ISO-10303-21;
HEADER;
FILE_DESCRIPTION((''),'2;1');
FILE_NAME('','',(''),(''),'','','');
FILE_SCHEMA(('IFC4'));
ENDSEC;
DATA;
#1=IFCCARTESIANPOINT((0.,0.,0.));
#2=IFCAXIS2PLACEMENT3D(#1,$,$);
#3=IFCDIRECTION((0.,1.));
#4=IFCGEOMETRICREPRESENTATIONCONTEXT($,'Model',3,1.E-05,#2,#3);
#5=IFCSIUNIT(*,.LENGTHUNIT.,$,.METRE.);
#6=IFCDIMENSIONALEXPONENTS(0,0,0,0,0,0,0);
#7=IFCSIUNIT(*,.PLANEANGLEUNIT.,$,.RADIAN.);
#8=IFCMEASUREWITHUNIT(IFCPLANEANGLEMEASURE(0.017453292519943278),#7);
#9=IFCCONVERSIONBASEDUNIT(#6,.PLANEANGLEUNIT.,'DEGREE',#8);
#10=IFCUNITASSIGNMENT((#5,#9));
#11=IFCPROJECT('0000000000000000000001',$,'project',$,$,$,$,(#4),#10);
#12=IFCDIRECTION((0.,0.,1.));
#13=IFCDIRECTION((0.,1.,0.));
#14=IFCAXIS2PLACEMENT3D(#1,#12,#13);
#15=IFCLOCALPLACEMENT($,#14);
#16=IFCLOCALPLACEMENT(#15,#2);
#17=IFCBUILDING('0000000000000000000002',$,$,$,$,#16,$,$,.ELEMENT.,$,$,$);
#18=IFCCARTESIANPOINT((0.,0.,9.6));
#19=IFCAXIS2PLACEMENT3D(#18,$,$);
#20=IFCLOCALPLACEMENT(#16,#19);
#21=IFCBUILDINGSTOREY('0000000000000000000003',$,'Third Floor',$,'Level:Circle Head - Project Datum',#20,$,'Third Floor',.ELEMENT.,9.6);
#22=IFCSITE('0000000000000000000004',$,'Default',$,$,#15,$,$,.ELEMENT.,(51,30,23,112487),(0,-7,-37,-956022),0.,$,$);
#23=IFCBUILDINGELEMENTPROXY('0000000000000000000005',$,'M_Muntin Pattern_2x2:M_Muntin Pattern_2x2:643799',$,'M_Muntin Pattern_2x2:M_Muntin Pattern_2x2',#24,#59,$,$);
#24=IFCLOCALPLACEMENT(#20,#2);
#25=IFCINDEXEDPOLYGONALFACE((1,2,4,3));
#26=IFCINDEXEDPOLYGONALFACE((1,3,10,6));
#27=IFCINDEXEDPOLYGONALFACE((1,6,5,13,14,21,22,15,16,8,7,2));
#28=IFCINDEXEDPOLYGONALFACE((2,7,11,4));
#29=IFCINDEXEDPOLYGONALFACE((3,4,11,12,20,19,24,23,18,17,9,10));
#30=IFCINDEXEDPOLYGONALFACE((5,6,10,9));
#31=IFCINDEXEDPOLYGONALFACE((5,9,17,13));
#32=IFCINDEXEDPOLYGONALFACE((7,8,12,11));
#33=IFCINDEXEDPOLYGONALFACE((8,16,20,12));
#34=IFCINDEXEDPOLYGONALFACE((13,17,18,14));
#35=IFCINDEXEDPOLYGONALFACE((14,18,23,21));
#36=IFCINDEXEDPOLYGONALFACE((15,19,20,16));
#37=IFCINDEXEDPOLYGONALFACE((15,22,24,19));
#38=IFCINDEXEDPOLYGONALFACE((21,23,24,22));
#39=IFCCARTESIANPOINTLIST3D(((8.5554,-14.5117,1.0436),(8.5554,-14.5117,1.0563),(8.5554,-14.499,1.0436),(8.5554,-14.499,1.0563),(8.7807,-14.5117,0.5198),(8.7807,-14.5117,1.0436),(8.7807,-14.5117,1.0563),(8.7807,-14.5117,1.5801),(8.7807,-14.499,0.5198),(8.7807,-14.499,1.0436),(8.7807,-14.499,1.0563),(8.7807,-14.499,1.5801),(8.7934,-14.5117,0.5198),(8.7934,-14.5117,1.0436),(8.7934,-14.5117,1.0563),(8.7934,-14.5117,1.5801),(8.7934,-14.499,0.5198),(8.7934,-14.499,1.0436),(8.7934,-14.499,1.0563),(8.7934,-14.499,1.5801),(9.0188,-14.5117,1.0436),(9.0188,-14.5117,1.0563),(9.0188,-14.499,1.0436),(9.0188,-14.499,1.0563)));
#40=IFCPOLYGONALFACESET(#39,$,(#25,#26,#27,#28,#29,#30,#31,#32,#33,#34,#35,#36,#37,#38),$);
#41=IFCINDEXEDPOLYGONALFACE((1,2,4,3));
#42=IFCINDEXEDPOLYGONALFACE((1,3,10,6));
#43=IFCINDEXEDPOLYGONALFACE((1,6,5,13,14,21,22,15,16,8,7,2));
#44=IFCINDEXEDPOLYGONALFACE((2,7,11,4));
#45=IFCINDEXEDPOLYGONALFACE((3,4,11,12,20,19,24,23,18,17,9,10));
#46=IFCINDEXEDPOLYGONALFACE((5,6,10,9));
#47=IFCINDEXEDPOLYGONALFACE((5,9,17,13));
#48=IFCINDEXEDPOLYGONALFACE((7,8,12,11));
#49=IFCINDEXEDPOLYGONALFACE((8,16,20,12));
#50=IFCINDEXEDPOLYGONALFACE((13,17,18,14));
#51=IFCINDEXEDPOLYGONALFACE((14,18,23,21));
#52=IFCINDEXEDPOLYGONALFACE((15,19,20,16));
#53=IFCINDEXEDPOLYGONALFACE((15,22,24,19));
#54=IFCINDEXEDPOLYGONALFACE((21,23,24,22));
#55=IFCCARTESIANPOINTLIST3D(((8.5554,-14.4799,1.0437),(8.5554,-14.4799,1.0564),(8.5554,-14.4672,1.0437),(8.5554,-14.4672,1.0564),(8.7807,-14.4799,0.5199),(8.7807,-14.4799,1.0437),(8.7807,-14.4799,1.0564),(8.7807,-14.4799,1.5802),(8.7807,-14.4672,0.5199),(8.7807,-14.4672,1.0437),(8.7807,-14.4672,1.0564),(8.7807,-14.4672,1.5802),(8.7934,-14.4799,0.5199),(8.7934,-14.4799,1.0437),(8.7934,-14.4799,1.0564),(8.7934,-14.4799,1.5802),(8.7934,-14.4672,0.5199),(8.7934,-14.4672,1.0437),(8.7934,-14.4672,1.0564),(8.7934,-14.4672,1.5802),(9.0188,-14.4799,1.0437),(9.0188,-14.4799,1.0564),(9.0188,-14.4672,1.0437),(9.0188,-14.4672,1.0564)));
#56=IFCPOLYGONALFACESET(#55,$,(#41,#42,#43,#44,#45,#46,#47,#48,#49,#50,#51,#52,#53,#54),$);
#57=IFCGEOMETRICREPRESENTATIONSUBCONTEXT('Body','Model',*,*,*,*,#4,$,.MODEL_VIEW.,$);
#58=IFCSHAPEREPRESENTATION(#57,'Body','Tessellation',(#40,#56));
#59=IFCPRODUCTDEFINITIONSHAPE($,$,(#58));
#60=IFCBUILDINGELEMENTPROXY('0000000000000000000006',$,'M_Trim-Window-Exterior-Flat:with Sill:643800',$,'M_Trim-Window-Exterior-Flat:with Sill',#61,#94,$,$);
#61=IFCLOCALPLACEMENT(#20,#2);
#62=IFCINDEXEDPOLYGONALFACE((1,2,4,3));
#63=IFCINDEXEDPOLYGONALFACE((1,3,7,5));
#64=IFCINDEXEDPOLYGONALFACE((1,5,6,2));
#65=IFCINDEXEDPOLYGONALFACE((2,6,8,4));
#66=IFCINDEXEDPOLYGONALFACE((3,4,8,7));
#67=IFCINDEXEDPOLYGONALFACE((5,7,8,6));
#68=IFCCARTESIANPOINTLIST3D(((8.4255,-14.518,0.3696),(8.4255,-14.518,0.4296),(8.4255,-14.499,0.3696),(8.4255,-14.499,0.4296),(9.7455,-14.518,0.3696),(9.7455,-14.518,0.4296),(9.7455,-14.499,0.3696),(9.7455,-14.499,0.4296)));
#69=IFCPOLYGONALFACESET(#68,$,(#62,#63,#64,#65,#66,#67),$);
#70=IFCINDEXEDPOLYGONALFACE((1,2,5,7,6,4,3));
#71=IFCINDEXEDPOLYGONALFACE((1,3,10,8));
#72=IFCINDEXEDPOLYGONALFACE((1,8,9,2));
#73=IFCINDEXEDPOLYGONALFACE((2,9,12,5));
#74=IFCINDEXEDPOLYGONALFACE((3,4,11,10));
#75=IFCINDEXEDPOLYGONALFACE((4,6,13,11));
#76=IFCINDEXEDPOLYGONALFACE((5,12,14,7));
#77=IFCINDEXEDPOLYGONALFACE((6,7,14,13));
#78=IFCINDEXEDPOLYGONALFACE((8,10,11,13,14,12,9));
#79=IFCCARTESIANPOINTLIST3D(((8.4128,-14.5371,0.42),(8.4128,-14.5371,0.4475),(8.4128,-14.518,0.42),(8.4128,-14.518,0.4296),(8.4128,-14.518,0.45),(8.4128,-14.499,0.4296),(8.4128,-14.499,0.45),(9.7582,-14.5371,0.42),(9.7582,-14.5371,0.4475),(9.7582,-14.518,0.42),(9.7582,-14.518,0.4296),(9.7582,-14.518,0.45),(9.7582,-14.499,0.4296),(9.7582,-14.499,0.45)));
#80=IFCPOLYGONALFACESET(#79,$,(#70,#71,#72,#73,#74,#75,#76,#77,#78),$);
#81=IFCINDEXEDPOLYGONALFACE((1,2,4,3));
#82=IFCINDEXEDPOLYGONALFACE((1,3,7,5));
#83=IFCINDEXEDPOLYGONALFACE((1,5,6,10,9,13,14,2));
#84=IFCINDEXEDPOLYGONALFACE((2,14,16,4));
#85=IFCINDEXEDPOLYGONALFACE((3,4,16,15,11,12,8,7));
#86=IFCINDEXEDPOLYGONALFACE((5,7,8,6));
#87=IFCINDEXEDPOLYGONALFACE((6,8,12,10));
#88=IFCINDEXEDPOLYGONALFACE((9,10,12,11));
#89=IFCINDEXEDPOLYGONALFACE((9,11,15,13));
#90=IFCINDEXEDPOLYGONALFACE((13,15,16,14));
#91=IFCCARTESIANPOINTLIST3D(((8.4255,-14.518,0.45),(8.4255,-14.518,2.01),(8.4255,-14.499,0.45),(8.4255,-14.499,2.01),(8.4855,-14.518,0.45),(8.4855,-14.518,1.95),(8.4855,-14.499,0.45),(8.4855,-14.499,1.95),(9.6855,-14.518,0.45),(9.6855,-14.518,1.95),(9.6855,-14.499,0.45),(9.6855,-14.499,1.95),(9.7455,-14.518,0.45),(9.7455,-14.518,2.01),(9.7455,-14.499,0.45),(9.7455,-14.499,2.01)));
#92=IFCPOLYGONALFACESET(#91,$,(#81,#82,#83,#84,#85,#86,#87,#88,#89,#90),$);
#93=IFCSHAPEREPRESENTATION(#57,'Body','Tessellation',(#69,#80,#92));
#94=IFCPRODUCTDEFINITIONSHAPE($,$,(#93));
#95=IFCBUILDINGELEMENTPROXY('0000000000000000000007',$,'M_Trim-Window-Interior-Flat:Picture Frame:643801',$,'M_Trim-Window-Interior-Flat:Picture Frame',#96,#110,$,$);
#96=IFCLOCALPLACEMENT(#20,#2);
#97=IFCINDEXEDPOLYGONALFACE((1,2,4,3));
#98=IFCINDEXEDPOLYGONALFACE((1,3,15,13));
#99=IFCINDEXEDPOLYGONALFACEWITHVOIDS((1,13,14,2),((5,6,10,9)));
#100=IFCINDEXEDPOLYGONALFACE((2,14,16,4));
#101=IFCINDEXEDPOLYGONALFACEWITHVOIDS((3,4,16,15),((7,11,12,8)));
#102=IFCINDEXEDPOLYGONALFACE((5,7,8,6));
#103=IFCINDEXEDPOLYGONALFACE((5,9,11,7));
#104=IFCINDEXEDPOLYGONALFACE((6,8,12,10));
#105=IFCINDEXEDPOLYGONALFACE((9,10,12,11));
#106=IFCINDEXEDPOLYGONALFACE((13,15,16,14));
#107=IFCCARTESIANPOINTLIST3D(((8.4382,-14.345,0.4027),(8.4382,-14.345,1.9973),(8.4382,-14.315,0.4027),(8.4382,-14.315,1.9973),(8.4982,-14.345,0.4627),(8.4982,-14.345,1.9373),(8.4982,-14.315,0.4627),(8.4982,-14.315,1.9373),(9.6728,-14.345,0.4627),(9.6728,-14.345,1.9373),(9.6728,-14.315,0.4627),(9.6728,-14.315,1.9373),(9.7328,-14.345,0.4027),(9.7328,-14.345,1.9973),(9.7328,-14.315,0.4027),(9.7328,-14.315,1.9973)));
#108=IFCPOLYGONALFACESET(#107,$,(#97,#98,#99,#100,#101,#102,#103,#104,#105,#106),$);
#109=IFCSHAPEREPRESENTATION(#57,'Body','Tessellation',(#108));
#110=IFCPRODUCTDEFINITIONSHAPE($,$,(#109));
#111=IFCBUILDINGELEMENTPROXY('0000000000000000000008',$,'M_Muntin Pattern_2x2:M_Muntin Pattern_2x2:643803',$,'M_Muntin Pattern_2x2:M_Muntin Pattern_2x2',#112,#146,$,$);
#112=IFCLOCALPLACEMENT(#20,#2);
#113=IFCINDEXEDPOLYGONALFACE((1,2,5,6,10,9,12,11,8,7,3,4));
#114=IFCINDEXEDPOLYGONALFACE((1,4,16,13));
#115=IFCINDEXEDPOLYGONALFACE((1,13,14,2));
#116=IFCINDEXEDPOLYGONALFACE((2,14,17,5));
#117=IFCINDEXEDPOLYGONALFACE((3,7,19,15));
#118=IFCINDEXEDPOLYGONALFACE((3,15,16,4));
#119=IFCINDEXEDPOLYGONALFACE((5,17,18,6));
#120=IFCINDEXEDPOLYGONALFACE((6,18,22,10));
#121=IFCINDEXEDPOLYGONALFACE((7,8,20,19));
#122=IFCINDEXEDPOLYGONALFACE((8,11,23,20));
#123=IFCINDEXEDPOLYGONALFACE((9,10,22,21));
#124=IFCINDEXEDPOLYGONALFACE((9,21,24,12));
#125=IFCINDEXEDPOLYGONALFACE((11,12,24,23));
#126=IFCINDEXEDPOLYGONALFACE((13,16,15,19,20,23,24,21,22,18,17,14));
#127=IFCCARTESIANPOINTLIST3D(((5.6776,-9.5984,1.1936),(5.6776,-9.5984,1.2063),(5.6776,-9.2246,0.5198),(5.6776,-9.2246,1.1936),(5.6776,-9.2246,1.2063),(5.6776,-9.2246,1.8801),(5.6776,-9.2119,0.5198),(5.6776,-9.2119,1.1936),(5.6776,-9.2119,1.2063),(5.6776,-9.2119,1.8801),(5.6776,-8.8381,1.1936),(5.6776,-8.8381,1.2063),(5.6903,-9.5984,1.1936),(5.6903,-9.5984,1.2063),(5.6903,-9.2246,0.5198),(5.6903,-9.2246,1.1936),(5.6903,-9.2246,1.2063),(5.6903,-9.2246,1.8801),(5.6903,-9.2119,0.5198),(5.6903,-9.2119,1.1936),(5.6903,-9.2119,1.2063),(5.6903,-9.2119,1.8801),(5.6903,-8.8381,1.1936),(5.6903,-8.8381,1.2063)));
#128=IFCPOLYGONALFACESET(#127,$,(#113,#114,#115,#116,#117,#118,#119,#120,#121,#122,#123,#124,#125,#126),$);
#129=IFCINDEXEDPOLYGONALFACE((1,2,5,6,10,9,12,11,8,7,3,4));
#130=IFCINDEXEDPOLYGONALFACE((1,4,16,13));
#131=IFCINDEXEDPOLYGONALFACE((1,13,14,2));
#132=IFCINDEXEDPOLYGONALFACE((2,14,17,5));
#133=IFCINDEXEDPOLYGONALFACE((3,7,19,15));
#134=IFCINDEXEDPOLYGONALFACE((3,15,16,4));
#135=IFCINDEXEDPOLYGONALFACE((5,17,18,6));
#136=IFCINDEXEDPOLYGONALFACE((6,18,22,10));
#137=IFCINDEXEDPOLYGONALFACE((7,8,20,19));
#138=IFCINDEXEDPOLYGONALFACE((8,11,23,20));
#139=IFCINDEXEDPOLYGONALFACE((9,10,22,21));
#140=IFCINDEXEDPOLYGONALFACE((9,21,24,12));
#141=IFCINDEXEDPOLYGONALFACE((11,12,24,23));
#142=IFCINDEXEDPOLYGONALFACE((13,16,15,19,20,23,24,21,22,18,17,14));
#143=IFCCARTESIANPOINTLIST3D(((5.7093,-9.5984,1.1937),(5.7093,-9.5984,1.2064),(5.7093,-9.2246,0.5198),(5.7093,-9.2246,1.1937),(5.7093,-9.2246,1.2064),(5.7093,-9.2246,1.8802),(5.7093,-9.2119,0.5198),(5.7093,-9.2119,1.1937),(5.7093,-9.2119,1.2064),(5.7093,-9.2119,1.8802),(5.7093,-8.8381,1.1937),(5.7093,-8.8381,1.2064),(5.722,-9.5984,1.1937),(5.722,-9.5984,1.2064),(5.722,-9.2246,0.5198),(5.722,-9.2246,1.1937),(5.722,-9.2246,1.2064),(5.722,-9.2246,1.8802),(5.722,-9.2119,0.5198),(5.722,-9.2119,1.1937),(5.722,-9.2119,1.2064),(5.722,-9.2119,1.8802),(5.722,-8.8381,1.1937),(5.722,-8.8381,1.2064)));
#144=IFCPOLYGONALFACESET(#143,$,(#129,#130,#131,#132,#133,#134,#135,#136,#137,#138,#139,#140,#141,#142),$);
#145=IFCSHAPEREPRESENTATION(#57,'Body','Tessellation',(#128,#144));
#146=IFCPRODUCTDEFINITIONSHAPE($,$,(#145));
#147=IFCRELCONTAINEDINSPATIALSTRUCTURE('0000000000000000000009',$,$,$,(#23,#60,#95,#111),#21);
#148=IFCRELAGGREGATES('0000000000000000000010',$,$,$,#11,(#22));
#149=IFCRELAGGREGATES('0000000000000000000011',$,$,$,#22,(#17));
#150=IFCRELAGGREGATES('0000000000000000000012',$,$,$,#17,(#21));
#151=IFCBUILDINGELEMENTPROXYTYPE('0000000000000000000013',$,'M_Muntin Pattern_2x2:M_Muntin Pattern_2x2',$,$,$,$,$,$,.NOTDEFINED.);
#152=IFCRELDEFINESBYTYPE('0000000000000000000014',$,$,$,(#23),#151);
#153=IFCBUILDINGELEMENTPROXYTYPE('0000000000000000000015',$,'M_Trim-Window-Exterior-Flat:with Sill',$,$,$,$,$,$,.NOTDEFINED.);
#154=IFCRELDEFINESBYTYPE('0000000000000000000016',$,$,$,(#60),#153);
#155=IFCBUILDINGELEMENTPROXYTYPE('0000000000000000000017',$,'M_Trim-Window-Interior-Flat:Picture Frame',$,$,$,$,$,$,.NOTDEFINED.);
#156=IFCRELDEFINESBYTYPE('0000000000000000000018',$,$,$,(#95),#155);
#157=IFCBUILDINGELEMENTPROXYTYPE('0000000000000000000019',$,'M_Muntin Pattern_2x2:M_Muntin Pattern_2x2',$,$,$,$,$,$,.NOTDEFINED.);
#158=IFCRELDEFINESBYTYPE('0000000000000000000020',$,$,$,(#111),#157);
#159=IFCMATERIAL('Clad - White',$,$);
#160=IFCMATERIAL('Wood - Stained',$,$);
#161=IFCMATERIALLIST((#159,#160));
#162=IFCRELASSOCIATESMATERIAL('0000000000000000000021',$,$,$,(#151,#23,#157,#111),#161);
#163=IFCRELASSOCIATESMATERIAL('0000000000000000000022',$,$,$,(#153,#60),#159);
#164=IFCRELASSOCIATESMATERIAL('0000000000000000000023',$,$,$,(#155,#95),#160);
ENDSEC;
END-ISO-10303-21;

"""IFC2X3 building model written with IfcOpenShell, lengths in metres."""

from ifc_helpers import new_model, entity, si_unit, converted_unit, direction, frame, frame_2d, origin, place, context, subcontext, project, spatial, polyline, rectangle, outline, extrude, source, transform, mapped, material, material_list, type_object, type_shapes, element, save


model = new_model("IFC2X3")

# Units and contexts
model_context = context("Model", 3, precision=1e-05, world=origin(), true_north=direction((0.0, 1.0)))
body_context = subcontext(model_context, "Body", "Model", "MODEL_VIEW")
ifc_project = project(units=[si_unit("LENGTHUNIT", "METRE"), converted_unit("PLANEANGLEUNIT", "DEGREE", entity("IfcPlaneAngleMeasure", 0.017453292519943278), si_unit("PLANEANGLEUNIT", "RADIAN"), dimensions=[0, 0, 0, 0, 0, 0, 0])], contexts=[model_context])

# Site, building, storey
site_placement = place(None, frame((0.0, 0.0, 0.0), z_axis=(0.0, 0.0, 1.0), x_axis=(0.0, 1.0, 0.0)))
site = spatial("IfcSite", under=ifc_project, at=site_placement, Name="Default", CompositionType="ELEMENT", RefLatitude=(51, 30, 23, 112487), RefLongitude=(0, -7, -37, -956022), RefElevation=0.0)
building_placement = place(site_placement, origin())
building = spatial("IfcBuilding", under=site, at=building_placement, CompositionType="ELEMENT")
storey_placement = place(building_placement, frame((0.0, 0.0, 9.6)))
storey = spatial("IfcBuildingStorey", under=building, at=storey_placement, Name="Third Floor", ObjectType="Level:Circle Head - Project Datum", LongName="Third Floor", CompositionType="ELEMENT", Elevation=9.6)

# Building element proxies
ifc_material_1 = material(Name="Clad - White")
ifc_material_2 = material(Name="Wood - Stained")
ifc_material_list = material_list([ifc_material_1, ifc_material_2])
building_element_proxy_type_1 = type_object("IfcBuildingElementProxyType", Name="M_Muntin Pattern_2x2:M_Muntin Pattern_2x2", PredefinedType="NOTDEFINED", material=ifc_material_list)
shared_shape_1 = source(origin(), body_context, "Body", "SweptSolid", [
    extrude(outline(polyline([(0.0064, -0.0064), (0.5301, -0.0064), (0.5301, 0.0063), (0.0064, 0.0063), (0.0064, 0.2317), (-0.0063, 0.2317), (-0.0063, 0.0063), (-0.5302, 0.0063), (-0.5302, -0.0064), (-0.0063, -0.0064), (-0.0063, -0.2317), (0.0064, -0.2317), (0.0064, -0.0064)])), frame((0.0, -0.0222, 0.5301), z_axis=(0.0, 1.0, 0.0), x_axis=(0.0, 0.0, 1.0)), (0.0, 0.0, 1.0), 0.0127),
    extrude(outline(polyline([(0.0064, -0.0064), (0.5302, -0.0064), (0.5302, 0.0063), (0.0064, 0.0063), (0.0064, 0.2317), (-0.0063, 0.2317), (-0.0063, 0.0063), (-0.5302, 0.0063), (-0.5302, -0.0064), (-0.0063, -0.0064), (-0.0063, -0.2317), (0.0064, -0.2317), (0.0064, -0.0064)])), frame((0.0, 0.0095, 0.5302), z_axis=(0.0, 1.0, 0.0), x_axis=(0.0, 0.0, 1.0)), (0.0, 0.0, 1.0), 0.0127),
])
type_shapes(building_element_proxy_type_1, [shared_shape_1])
proxy_1_placement = place(storey_placement, frame((8.7871, -14.4895, 0.5199)))
element("IfcBuildingElementProxy", 1, at=proxy_1_placement, inside=storey, type_object=building_element_proxy_type_1, material=ifc_material_list, Name="M_Muntin Pattern_2x2:M_Muntin Pattern_2x2:643799", ObjectType="M_Muntin Pattern_2x2:M_Muntin Pattern_2x2", context=body_context, shape_type="MappedRepresentation", body=[
    mapped(shared_shape_1, transform((0.0, 0.0, 0.0), scale=1.0)),
])
building_element_proxy_type_2 = type_object("IfcBuildingElementProxyType", Name="M_Trim-Window-Exterior-Flat:with Sill", PredefinedType="NOTDEFINED", material=ifc_material_1)
shared_shape_2 = source(origin(), body_context, "Body", "SweptSolid", [
    extrude(rectangle(XDim=1.32, YDim=0.06, at=frame_2d((0.0, 0.0), x_axis=(1.0, 0.0))), frame((0.0, -1.5504, 0.0), z_axis=(0.0, 0.0, 1.0), x_axis=(-1.0, 0.0, 0.0)), (0.0, 0.0, 1.0), 0.019),
    extrude(outline(polyline([(-0.019, -0.0152), (0.0, -0.0152), (0.0, -0.0057), (0.019, -0.0057), (0.019, 0.0148), (0.0, 0.0148), (-0.019, 0.0123), (-0.019, -0.0152)])), frame((-0.6727, -1.5148, 0.019), z_axis=(1.0, 0.0, 0.0), x_axis=(0.0, 0.0, -1.0)), (0.0, 0.0, 1.0), 1.3454),
    extrude(outline(polyline([(-0.795, -0.66), (0.765, -0.66), (0.765, -0.6), (-0.735, -0.6), (-0.735, 0.6), (0.765, 0.6), (0.765, 0.66), (-0.795, 0.66), (-0.795, -0.66)])), frame((0.0, -0.735, 0.0), z_axis=(0.0, 0.0, 1.0), x_axis=(0.0, -1.0, 0.0)), (0.0, 0.0, 1.0), 0.019),
])
type_shapes(building_element_proxy_type_2, [shared_shape_2])
proxy_2_placement = place(storey_placement, frame((9.0855, -14.499, 1.95), z_axis=(0.0, -1.0, 0.0), x_axis=(1.0, 0.0, 0.0)))
element("IfcBuildingElementProxy", 2, at=proxy_2_placement, inside=storey, type_object=building_element_proxy_type_2, material=ifc_material_1, Name="M_Trim-Window-Exterior-Flat:with Sill:643800", ObjectType="M_Trim-Window-Exterior-Flat:with Sill", context=body_context, shape_type="MappedRepresentation", body=[
    mapped(shared_shape_2, transform((0.0, 0.0, 0.0), scale=1.0)),
])
building_element_proxy_type_3 = type_object("IfcBuildingElementProxyType", Name="M_Trim-Window-Interior-Flat:Picture Frame", PredefinedType="NOTDEFINED", material=ifc_material_2)
shared_shape_3 = source(origin(), body_context, "Body", "SweptSolid", [
    extrude(outline(polyline([(-0.6473, -0.7973), (0.6473, -0.7973), (0.6473, 0.7973), (-0.6473, 0.7973), (-0.6473, -0.7973)]), holes=[polyline([(-0.5873, -0.7373), (-0.5873, 0.7373), (0.5873, 0.7373), (0.5873, -0.7373), (-0.5873, -0.7373)])]), frame((0.0, -0.75, 0.0), z_axis=(0.0, 0.0, 1.0), x_axis=(-1.0, 0.0, 0.0)), (0.0, 0.0, 1.0), 0.03),
])
type_shapes(building_element_proxy_type_3, [shared_shape_3])
proxy_3_placement = place(storey_placement, frame((9.0855, -14.345, 1.95), z_axis=(0.0, 1.0, 0.0), x_axis=(-1.0, 0.0, 0.0)))
element("IfcBuildingElementProxy", 3, at=proxy_3_placement, inside=storey, type_object=building_element_proxy_type_3, material=ifc_material_2, Name="M_Trim-Window-Interior-Flat:Picture Frame:643801", ObjectType="M_Trim-Window-Interior-Flat:Picture Frame", context=body_context, shape_type="MappedRepresentation", body=[
    mapped(shared_shape_3, transform((0.0, 0.0, 0.0), scale=1.0)),
])
building_element_proxy_type_4 = type_object("IfcBuildingElementProxyType", Name="M_Muntin Pattern_2x2:M_Muntin Pattern_2x2", PredefinedType="NOTDEFINED", material=ifc_material_list)
shared_shape_4 = source(origin(), body_context, "Body", "SweptSolid", [
    extrude(outline(polyline([(0.0064, -0.0064), (0.6801, -0.0064), (0.6801, 0.0063), (0.0064, 0.0063), (0.0064, 0.3802), (-0.0063, 0.3802), (-0.0063, 0.0063), (-0.6802, 0.0063), (-0.6802, -0.0064), (-0.0063, -0.0064), (-0.0063, -0.3801), (0.0064, -0.3801), (0.0064, -0.0064)])), frame((0.0, 0.0095, 0.6801), z_axis=(0.0, 1.0, 0.0), x_axis=(0.0, 0.0, 1.0)), (0.0, 0.0, 1.0), 0.0127),
    extrude(outline(polyline([(0.0064, -0.0064), (0.6802, -0.0064), (0.6802, 0.0063), (0.0064, 0.0063), (0.0064, 0.3802), (-0.0063, 0.3802), (-0.0063, 0.0063), (-0.6802, 0.0063), (-0.6802, -0.0064), (-0.0063, -0.0064), (-0.0063, -0.3801), (0.0064, -0.3801), (0.0064, -0.0064)])), frame((0.0, -0.0222, 0.6802), z_axis=(0.0, 1.0, 0.0), x_axis=(0.0, 0.0, 1.0)), (0.0, 0.0, 1.0), 0.0127),
])
type_shapes(building_element_proxy_type_4, [shared_shape_4])
proxy_4_placement = place(storey_placement, frame((5.6998, -9.2183, 0.5198), z_axis=(0.0, 0.0, 1.0), x_axis=(0.0, 1.0, 0.0)))
element("IfcBuildingElementProxy", 4, at=proxy_4_placement, inside=storey, type_object=building_element_proxy_type_4, material=ifc_material_list, Name="M_Muntin Pattern_2x2:M_Muntin Pattern_2x2:643803", ObjectType="M_Muntin Pattern_2x2:M_Muntin Pattern_2x2", context=body_context, shape_type="MappedRepresentation", body=[
    mapped(shared_shape_4, transform((0.0, 0.0, 0.0), scale=1.0)),
])

save(model, "model.ifc")
